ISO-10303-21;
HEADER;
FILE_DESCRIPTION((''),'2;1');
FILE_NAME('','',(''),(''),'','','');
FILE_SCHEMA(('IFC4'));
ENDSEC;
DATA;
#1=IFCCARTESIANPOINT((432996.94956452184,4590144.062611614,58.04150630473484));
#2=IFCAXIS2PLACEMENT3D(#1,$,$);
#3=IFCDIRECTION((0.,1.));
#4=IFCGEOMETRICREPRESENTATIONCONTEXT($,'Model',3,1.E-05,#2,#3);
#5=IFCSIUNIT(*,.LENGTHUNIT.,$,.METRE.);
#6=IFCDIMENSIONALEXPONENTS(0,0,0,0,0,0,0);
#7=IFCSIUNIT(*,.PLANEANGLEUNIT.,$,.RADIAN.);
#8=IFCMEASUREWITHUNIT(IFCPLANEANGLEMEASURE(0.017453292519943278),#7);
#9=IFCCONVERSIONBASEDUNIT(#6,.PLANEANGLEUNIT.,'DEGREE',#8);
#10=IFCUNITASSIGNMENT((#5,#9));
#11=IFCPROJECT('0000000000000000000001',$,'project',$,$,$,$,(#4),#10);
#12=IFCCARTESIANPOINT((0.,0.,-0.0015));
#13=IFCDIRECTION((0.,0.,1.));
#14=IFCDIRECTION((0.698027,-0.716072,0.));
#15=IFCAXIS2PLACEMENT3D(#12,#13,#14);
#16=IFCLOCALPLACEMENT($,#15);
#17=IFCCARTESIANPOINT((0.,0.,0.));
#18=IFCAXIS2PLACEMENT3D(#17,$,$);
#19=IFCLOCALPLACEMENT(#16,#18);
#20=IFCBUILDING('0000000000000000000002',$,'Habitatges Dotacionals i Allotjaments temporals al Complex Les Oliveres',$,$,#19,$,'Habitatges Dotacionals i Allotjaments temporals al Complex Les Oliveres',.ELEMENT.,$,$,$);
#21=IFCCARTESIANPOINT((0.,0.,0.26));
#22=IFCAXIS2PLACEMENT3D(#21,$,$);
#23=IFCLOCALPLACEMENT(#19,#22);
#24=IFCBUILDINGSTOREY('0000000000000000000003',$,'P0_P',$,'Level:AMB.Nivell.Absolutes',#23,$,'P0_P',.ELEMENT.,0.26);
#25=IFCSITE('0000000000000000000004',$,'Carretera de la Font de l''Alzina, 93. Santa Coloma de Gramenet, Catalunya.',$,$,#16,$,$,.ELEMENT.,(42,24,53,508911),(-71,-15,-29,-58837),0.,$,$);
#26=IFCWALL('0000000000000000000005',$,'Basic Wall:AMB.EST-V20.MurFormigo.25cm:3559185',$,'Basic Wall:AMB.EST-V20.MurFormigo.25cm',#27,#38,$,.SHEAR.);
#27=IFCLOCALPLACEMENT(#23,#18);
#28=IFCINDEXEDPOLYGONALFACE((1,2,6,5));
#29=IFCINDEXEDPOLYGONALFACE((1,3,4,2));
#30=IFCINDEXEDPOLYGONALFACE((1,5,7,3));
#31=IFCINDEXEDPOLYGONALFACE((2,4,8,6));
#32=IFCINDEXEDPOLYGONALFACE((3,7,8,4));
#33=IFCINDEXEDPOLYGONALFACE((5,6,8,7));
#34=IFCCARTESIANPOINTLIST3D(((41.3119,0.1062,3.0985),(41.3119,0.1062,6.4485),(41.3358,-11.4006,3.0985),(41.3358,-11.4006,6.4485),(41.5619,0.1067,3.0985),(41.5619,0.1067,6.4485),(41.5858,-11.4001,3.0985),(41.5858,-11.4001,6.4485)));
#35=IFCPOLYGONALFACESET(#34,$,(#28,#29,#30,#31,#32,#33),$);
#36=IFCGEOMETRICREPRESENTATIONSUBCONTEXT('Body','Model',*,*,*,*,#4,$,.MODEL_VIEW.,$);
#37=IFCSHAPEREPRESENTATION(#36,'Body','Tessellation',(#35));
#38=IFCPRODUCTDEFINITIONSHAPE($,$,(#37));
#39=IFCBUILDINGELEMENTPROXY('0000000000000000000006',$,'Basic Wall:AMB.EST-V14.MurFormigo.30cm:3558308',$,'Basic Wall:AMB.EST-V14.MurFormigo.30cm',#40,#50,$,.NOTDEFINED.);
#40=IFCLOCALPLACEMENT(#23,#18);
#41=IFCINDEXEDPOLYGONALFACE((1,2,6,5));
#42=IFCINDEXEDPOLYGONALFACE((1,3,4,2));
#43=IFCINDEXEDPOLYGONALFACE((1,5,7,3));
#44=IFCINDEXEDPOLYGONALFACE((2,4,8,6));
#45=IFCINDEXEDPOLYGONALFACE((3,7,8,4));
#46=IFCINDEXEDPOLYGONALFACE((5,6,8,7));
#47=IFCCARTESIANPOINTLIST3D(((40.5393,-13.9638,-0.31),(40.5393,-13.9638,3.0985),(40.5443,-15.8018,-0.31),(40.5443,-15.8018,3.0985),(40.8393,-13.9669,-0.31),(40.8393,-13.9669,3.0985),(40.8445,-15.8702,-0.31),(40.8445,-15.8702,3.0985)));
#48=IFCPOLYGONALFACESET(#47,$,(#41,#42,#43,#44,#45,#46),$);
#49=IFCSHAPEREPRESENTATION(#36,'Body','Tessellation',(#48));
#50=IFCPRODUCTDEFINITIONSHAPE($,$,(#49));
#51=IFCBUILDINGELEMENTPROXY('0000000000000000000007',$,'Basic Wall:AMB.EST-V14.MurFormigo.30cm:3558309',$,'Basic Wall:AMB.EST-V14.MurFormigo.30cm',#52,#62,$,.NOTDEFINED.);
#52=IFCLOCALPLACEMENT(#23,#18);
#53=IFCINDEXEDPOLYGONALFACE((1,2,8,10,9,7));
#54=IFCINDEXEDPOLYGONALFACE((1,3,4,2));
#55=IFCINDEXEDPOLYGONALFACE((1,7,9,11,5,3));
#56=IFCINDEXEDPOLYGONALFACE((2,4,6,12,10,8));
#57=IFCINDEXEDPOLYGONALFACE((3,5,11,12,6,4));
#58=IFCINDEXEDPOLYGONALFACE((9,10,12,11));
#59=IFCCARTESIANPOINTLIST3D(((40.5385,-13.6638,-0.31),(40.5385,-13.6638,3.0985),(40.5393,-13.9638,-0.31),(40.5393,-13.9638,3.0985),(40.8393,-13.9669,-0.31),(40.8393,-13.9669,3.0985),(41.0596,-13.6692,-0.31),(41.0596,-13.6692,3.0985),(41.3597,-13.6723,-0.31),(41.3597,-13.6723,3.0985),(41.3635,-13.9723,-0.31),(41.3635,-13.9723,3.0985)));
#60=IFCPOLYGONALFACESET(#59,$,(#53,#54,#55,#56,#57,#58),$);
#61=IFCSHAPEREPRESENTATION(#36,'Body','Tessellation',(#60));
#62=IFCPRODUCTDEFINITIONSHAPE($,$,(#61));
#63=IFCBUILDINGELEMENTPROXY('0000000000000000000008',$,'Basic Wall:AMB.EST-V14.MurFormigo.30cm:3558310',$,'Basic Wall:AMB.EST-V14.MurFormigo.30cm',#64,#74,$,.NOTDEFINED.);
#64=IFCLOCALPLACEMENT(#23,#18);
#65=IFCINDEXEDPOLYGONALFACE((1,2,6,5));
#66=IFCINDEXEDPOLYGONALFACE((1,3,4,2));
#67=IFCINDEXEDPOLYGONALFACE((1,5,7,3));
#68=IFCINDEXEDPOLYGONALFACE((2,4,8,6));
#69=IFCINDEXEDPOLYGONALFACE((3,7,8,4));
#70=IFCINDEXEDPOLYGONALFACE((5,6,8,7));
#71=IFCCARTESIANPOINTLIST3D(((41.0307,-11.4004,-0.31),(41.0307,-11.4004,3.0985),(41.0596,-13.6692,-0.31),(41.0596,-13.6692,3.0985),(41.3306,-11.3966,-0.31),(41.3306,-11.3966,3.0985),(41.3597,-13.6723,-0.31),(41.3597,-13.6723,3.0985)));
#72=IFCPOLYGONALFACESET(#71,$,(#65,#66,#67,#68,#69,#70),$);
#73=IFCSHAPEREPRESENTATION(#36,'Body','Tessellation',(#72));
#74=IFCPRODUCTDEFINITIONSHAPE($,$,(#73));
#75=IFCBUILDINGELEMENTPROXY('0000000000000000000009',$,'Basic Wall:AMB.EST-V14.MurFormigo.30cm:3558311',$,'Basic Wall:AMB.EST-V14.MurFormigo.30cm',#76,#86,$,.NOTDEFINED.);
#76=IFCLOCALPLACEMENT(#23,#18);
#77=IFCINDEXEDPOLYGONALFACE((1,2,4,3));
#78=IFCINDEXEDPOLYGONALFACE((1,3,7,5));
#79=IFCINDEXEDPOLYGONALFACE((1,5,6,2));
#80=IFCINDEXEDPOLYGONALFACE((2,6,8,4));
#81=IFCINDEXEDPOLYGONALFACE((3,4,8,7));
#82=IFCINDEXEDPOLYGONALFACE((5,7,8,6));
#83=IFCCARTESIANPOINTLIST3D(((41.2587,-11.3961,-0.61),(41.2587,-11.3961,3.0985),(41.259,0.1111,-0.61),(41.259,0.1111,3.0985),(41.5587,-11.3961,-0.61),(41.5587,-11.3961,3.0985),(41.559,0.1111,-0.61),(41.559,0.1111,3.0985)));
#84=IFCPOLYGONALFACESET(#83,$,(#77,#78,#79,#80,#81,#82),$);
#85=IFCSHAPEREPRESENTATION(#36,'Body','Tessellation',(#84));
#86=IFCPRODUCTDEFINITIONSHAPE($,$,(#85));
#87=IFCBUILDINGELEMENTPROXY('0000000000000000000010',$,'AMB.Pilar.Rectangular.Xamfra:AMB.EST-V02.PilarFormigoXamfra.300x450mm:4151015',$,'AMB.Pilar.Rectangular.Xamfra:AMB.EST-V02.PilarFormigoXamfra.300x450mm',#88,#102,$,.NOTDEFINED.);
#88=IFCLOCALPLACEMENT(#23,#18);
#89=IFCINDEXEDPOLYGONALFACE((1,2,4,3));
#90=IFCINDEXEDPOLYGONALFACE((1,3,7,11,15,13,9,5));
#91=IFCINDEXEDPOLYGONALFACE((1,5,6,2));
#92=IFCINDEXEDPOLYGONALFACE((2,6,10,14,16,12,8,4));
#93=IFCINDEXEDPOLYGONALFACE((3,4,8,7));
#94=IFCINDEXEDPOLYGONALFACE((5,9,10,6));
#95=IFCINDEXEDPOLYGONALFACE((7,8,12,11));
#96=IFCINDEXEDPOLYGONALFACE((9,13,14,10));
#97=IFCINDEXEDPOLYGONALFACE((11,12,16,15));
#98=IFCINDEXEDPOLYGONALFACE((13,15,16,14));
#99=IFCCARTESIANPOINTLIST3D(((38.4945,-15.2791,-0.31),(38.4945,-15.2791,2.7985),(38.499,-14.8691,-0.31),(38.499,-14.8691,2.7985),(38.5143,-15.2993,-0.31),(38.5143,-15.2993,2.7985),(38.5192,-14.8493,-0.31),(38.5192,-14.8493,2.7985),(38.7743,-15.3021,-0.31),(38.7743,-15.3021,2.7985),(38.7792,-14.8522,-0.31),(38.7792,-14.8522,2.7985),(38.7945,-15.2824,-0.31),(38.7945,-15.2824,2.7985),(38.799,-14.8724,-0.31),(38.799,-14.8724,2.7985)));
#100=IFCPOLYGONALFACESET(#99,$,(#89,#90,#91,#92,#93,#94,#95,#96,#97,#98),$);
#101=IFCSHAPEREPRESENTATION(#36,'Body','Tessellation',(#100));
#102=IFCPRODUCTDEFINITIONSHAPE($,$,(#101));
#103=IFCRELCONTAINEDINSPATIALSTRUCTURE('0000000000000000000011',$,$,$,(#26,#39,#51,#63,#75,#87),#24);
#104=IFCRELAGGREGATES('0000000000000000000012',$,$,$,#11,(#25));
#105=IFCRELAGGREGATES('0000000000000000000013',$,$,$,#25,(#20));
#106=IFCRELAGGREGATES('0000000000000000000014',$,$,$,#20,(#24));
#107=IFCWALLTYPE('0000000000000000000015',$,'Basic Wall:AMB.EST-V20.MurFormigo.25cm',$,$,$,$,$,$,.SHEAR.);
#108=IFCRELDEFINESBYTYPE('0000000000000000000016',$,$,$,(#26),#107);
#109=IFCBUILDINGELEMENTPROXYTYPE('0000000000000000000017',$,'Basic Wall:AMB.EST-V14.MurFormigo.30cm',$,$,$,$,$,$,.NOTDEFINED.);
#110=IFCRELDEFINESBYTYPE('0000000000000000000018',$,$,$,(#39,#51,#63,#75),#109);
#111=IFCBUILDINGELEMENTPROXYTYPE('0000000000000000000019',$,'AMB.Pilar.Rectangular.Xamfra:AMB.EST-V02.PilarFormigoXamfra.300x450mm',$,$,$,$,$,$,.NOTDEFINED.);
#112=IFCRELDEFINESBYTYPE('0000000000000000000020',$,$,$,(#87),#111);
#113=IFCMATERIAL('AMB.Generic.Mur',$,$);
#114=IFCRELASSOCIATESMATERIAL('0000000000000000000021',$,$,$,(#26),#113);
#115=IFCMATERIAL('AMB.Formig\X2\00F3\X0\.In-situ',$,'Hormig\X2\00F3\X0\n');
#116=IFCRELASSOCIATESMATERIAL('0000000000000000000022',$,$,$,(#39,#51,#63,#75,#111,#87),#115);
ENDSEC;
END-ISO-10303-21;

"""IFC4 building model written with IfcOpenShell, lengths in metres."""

from ifc_helpers import new_model, entity, si_unit, converted_unit, direction, frame, origin, place, context, subcontext, project, spatial, indexed_curve, outline, extrude, source, transform, mapped, material, type_object, type_shapes, element, save


model = new_model("IFC4")

# Units and contexts
model_context = context("Model", 3, precision=1e-05, world=frame((432996.94956452184, 4590144.062611614, 58.04150630473484)), true_north=direction((0.0, 1.0)))
body_context = subcontext(model_context, "Body", "Model", "MODEL_VIEW")
ifc_project = project(units=[si_unit("LENGTHUNIT", "METRE"), converted_unit("PLANEANGLEUNIT", "DEGREE", entity("IfcPlaneAngleMeasure", 0.017453292519943278), si_unit("PLANEANGLEUNIT", "RADIAN"), dimensions=[0, 0, 0, 0, 0, 0, 0])], contexts=[model_context])

# Site, building, storey
site_placement = place(None, frame((0.0, 0.0, -0.0015), z_axis=(0.0, 0.0, 1.0), x_axis=(0.698027, -0.716072, 0.0)))
site = spatial("IfcSite", under=ifc_project, at=site_placement, Name="Carretera de la Font de l'Alzina, 93. Santa Coloma de Gramenet, Catalunya.", CompositionType="ELEMENT", RefLatitude=(42, 24, 53, 508911), RefLongitude=(-71, -15, -29, -58837), RefElevation=0.0)
building_placement = place(site_placement, origin())
building = spatial("IfcBuilding", under=site, at=building_placement, Name="Habitatges Dotacionals i Allotjaments temporals al Complex Les Oliveres", LongName="Habitatges Dotacionals i Allotjaments temporals al Complex Les Oliveres", CompositionType="ELEMENT")
storey_placement = place(building_placement, frame((0.0, 0.0, 0.26)))
storey = spatial("IfcBuildingStorey", under=building, at=storey_placement, Name="P0_P", ObjectType="Level:AMB.Nivell.Absolutes", LongName="P0_P", CompositionType="ELEMENT", Elevation=0.26)

# Shared definitions
ifc_material_1 = material(Name="AMB.Formigó.In-situ", Category="Hormigón")

# Wall
ifc_material_2 = material(Name="AMB.Generic.Mur")
wall_type_1 = type_object("IfcWallType", Name="Basic Wall:AMB.EST-V20.MurFormigo.25cm", PredefinedType="SHEAR")
wall_1_placement = place(storey_placement, frame((41.4608, -11.4003, 3.0985), z_axis=(0.0, 0.0, 1.0), x_axis=(-0.002085, 0.999998, 0.0)))
element("IfcWall", 1, at=wall_1_placement, inside=storey, type_object=wall_type_1, material=ifc_material_2, Name="Basic Wall:AMB.EST-V20.MurFormigo.25cm:3559185", ObjectType="Basic Wall:AMB.EST-V20.MurFormigo.25cm", PredefinedType="SHEAR", context=body_context, shape_type="SweptSolid", body=[
    extrude(outline(indexed_curve([(11.5068, 0.125), (0.0, 0.125), (0.0, -0.125), (11.5068, -0.125), (11.5068, 0.125)], self_intersect=False)), origin(), (0.0, 0.0, 1.0), 3.35),
])

# Building element proxies
building_element_proxy_type_1 = type_object("IfcBuildingElementProxyType", Name="Basic Wall:AMB.EST-V14.MurFormigo.30cm", PredefinedType="NOTDEFINED")
proxy_1_placement = place(storey_placement, frame((40.6945, -15.8707, -0.31), z_axis=(0.0, 0.0, 1.0), x_axis=(-0.002741, 0.999996, 0.0)))
element("IfcBuildingElementProxy", 2, at=proxy_1_placement, inside=storey, type_object=building_element_proxy_type_1, material=ifc_material_1, Name="Basic Wall:AMB.EST-V14.MurFormigo.30cm:3558308", ObjectType="Basic Wall:AMB.EST-V14.MurFormigo.30cm", PredefinedType="NOTDEFINED", context=body_context, shape_type="SweptSolid", body=[
    extrude(outline(indexed_curve([(1.9033, -0.15), (1.9073, 0.15), (0.0692, 0.15), (0.0, -0.15), (1.9033, -0.15)], self_intersect=False)), origin(), (0.0, 0.0, 1.0), 3.4085),
])
proxy_2_placement = place(storey_placement, frame((40.5369, -13.8138, -0.31), z_axis=(0.0, 0.0, 1.0), x_axis=(0.999947, -0.010312, 0.0)))
element("IfcBuildingElementProxy", 3, at=proxy_2_placement, inside=storey, type_object=building_element_proxy_type_1, material=ifc_material_1, Name="Basic Wall:AMB.EST-V14.MurFormigo.30cm:3558309", ObjectType="Basic Wall:AMB.EST-V14.MurFormigo.30cm", PredefinedType="NOTDEFINED", context=body_context, shape_type="SweptSolid", body=[
    extrude(outline(indexed_curve([(0.8282, -0.15), (0.8212, 0.15), (0.5212, 0.15), (0.0, 0.15), (0.0039, -0.15), (0.3039, -0.15), (0.8282, -0.15)], self_intersect=False)), origin(), (0.0, 0.0, 1.0), 3.4085),
])
proxy_3_placement = place(storey_placement, frame((41.2097, -13.6742, -0.31), z_axis=(0.0, 0.0, 1.0), x_axis=(-0.01276, 0.999919, 0.0)))
element("IfcBuildingElementProxy", 4, at=proxy_3_placement, inside=storey, type_object=building_element_proxy_type_1, material=ifc_material_1, Name="Basic Wall:AMB.EST-V14.MurFormigo.30cm:3558310", ObjectType="Basic Wall:AMB.EST-V14.MurFormigo.30cm", PredefinedType="NOTDEFINED", context=body_context, shape_type="SweptSolid", body=[
    extrude(outline(indexed_curve([(2.2759, -0.15), (2.2759, 0.15), (0.0069, 0.15), (0.0, -0.15), (2.2759, -0.15)], self_intersect=False)), origin(), (0.0, 0.0, 1.0), 3.4085),
])
proxy_4_placement = place(storey_placement, frame((41.4087, -11.3961, -0.61), z_axis=(0.0, 0.0, 1.0), x_axis=(0.000029, 1.0, 0.0)))
element("IfcBuildingElementProxy", 5, at=proxy_4_placement, inside=storey, type_object=building_element_proxy_type_1, material=ifc_material_1, Name="Basic Wall:AMB.EST-V14.MurFormigo.30cm:3558311", ObjectType="Basic Wall:AMB.EST-V14.MurFormigo.30cm", PredefinedType="NOTDEFINED", context=body_context, shape_type="SweptSolid", body=[
    extrude(outline(indexed_curve([(11.5073, 0.15), (0.0, 0.15), (0.0, -0.15), (11.5073, -0.15), (11.5073, 0.15)], self_intersect=False)), origin(), (0.0, 0.0, 1.0), 3.7085),
])
building_element_proxy_type_2 = type_object("IfcBuildingElementProxyType", Name="AMB.Pilar.Rectangular.Xamfra:AMB.EST-V02.PilarFormigoXamfra.300x450mm", PredefinedType="NOTDEFINED", material=ifc_material_1)
shared_shape_1 = source(origin(), body_context, "Body", "SweptSolid", [
    extrude(outline(indexed_curve([(-0.13, -0.225), (0.13, -0.225), (0.15, -0.205), (0.15, 0.205), (0.13, 0.225), (-0.13, 0.225), (-0.15, 0.205), (-0.15, -0.205), (-0.13, -0.225)], self_intersect=False)), frame((0.0, 0.0, -0.05), z_axis=(0.0, 0.0, 1.0), x_axis=(-1.0, 0.0, 0.0)), (0.0, 0.0, 1.0), 3.1085),
])
type_shapes(building_element_proxy_type_2, [shared_shape_1])
proxy_5_placement = place(storey_placement, frame((38.6468, -15.0757, -0.26), z_axis=(0.0, 0.0, 1.0), x_axis=(0.99994, -0.010964, 0.0)))
element("IfcBuildingElementProxy", 6, at=proxy_5_placement, inside=storey, type_object=building_element_proxy_type_2, material=ifc_material_1, Name="AMB.Pilar.Rectangular.Xamfra:AMB.EST-V02.PilarFormigoXamfra.300x450mm:4151015", ObjectType="AMB.Pilar.Rectangular.Xamfra:AMB.EST-V02.PilarFormigoXamfra.300x450mm", PredefinedType="NOTDEFINED", context=body_context, shape_type="MappedRepresentation", body=[
    mapped(shared_shape_1, transform((0.0, 0.0, 0.0), scale=1.0)),
])

save(model, "model.ifc")
